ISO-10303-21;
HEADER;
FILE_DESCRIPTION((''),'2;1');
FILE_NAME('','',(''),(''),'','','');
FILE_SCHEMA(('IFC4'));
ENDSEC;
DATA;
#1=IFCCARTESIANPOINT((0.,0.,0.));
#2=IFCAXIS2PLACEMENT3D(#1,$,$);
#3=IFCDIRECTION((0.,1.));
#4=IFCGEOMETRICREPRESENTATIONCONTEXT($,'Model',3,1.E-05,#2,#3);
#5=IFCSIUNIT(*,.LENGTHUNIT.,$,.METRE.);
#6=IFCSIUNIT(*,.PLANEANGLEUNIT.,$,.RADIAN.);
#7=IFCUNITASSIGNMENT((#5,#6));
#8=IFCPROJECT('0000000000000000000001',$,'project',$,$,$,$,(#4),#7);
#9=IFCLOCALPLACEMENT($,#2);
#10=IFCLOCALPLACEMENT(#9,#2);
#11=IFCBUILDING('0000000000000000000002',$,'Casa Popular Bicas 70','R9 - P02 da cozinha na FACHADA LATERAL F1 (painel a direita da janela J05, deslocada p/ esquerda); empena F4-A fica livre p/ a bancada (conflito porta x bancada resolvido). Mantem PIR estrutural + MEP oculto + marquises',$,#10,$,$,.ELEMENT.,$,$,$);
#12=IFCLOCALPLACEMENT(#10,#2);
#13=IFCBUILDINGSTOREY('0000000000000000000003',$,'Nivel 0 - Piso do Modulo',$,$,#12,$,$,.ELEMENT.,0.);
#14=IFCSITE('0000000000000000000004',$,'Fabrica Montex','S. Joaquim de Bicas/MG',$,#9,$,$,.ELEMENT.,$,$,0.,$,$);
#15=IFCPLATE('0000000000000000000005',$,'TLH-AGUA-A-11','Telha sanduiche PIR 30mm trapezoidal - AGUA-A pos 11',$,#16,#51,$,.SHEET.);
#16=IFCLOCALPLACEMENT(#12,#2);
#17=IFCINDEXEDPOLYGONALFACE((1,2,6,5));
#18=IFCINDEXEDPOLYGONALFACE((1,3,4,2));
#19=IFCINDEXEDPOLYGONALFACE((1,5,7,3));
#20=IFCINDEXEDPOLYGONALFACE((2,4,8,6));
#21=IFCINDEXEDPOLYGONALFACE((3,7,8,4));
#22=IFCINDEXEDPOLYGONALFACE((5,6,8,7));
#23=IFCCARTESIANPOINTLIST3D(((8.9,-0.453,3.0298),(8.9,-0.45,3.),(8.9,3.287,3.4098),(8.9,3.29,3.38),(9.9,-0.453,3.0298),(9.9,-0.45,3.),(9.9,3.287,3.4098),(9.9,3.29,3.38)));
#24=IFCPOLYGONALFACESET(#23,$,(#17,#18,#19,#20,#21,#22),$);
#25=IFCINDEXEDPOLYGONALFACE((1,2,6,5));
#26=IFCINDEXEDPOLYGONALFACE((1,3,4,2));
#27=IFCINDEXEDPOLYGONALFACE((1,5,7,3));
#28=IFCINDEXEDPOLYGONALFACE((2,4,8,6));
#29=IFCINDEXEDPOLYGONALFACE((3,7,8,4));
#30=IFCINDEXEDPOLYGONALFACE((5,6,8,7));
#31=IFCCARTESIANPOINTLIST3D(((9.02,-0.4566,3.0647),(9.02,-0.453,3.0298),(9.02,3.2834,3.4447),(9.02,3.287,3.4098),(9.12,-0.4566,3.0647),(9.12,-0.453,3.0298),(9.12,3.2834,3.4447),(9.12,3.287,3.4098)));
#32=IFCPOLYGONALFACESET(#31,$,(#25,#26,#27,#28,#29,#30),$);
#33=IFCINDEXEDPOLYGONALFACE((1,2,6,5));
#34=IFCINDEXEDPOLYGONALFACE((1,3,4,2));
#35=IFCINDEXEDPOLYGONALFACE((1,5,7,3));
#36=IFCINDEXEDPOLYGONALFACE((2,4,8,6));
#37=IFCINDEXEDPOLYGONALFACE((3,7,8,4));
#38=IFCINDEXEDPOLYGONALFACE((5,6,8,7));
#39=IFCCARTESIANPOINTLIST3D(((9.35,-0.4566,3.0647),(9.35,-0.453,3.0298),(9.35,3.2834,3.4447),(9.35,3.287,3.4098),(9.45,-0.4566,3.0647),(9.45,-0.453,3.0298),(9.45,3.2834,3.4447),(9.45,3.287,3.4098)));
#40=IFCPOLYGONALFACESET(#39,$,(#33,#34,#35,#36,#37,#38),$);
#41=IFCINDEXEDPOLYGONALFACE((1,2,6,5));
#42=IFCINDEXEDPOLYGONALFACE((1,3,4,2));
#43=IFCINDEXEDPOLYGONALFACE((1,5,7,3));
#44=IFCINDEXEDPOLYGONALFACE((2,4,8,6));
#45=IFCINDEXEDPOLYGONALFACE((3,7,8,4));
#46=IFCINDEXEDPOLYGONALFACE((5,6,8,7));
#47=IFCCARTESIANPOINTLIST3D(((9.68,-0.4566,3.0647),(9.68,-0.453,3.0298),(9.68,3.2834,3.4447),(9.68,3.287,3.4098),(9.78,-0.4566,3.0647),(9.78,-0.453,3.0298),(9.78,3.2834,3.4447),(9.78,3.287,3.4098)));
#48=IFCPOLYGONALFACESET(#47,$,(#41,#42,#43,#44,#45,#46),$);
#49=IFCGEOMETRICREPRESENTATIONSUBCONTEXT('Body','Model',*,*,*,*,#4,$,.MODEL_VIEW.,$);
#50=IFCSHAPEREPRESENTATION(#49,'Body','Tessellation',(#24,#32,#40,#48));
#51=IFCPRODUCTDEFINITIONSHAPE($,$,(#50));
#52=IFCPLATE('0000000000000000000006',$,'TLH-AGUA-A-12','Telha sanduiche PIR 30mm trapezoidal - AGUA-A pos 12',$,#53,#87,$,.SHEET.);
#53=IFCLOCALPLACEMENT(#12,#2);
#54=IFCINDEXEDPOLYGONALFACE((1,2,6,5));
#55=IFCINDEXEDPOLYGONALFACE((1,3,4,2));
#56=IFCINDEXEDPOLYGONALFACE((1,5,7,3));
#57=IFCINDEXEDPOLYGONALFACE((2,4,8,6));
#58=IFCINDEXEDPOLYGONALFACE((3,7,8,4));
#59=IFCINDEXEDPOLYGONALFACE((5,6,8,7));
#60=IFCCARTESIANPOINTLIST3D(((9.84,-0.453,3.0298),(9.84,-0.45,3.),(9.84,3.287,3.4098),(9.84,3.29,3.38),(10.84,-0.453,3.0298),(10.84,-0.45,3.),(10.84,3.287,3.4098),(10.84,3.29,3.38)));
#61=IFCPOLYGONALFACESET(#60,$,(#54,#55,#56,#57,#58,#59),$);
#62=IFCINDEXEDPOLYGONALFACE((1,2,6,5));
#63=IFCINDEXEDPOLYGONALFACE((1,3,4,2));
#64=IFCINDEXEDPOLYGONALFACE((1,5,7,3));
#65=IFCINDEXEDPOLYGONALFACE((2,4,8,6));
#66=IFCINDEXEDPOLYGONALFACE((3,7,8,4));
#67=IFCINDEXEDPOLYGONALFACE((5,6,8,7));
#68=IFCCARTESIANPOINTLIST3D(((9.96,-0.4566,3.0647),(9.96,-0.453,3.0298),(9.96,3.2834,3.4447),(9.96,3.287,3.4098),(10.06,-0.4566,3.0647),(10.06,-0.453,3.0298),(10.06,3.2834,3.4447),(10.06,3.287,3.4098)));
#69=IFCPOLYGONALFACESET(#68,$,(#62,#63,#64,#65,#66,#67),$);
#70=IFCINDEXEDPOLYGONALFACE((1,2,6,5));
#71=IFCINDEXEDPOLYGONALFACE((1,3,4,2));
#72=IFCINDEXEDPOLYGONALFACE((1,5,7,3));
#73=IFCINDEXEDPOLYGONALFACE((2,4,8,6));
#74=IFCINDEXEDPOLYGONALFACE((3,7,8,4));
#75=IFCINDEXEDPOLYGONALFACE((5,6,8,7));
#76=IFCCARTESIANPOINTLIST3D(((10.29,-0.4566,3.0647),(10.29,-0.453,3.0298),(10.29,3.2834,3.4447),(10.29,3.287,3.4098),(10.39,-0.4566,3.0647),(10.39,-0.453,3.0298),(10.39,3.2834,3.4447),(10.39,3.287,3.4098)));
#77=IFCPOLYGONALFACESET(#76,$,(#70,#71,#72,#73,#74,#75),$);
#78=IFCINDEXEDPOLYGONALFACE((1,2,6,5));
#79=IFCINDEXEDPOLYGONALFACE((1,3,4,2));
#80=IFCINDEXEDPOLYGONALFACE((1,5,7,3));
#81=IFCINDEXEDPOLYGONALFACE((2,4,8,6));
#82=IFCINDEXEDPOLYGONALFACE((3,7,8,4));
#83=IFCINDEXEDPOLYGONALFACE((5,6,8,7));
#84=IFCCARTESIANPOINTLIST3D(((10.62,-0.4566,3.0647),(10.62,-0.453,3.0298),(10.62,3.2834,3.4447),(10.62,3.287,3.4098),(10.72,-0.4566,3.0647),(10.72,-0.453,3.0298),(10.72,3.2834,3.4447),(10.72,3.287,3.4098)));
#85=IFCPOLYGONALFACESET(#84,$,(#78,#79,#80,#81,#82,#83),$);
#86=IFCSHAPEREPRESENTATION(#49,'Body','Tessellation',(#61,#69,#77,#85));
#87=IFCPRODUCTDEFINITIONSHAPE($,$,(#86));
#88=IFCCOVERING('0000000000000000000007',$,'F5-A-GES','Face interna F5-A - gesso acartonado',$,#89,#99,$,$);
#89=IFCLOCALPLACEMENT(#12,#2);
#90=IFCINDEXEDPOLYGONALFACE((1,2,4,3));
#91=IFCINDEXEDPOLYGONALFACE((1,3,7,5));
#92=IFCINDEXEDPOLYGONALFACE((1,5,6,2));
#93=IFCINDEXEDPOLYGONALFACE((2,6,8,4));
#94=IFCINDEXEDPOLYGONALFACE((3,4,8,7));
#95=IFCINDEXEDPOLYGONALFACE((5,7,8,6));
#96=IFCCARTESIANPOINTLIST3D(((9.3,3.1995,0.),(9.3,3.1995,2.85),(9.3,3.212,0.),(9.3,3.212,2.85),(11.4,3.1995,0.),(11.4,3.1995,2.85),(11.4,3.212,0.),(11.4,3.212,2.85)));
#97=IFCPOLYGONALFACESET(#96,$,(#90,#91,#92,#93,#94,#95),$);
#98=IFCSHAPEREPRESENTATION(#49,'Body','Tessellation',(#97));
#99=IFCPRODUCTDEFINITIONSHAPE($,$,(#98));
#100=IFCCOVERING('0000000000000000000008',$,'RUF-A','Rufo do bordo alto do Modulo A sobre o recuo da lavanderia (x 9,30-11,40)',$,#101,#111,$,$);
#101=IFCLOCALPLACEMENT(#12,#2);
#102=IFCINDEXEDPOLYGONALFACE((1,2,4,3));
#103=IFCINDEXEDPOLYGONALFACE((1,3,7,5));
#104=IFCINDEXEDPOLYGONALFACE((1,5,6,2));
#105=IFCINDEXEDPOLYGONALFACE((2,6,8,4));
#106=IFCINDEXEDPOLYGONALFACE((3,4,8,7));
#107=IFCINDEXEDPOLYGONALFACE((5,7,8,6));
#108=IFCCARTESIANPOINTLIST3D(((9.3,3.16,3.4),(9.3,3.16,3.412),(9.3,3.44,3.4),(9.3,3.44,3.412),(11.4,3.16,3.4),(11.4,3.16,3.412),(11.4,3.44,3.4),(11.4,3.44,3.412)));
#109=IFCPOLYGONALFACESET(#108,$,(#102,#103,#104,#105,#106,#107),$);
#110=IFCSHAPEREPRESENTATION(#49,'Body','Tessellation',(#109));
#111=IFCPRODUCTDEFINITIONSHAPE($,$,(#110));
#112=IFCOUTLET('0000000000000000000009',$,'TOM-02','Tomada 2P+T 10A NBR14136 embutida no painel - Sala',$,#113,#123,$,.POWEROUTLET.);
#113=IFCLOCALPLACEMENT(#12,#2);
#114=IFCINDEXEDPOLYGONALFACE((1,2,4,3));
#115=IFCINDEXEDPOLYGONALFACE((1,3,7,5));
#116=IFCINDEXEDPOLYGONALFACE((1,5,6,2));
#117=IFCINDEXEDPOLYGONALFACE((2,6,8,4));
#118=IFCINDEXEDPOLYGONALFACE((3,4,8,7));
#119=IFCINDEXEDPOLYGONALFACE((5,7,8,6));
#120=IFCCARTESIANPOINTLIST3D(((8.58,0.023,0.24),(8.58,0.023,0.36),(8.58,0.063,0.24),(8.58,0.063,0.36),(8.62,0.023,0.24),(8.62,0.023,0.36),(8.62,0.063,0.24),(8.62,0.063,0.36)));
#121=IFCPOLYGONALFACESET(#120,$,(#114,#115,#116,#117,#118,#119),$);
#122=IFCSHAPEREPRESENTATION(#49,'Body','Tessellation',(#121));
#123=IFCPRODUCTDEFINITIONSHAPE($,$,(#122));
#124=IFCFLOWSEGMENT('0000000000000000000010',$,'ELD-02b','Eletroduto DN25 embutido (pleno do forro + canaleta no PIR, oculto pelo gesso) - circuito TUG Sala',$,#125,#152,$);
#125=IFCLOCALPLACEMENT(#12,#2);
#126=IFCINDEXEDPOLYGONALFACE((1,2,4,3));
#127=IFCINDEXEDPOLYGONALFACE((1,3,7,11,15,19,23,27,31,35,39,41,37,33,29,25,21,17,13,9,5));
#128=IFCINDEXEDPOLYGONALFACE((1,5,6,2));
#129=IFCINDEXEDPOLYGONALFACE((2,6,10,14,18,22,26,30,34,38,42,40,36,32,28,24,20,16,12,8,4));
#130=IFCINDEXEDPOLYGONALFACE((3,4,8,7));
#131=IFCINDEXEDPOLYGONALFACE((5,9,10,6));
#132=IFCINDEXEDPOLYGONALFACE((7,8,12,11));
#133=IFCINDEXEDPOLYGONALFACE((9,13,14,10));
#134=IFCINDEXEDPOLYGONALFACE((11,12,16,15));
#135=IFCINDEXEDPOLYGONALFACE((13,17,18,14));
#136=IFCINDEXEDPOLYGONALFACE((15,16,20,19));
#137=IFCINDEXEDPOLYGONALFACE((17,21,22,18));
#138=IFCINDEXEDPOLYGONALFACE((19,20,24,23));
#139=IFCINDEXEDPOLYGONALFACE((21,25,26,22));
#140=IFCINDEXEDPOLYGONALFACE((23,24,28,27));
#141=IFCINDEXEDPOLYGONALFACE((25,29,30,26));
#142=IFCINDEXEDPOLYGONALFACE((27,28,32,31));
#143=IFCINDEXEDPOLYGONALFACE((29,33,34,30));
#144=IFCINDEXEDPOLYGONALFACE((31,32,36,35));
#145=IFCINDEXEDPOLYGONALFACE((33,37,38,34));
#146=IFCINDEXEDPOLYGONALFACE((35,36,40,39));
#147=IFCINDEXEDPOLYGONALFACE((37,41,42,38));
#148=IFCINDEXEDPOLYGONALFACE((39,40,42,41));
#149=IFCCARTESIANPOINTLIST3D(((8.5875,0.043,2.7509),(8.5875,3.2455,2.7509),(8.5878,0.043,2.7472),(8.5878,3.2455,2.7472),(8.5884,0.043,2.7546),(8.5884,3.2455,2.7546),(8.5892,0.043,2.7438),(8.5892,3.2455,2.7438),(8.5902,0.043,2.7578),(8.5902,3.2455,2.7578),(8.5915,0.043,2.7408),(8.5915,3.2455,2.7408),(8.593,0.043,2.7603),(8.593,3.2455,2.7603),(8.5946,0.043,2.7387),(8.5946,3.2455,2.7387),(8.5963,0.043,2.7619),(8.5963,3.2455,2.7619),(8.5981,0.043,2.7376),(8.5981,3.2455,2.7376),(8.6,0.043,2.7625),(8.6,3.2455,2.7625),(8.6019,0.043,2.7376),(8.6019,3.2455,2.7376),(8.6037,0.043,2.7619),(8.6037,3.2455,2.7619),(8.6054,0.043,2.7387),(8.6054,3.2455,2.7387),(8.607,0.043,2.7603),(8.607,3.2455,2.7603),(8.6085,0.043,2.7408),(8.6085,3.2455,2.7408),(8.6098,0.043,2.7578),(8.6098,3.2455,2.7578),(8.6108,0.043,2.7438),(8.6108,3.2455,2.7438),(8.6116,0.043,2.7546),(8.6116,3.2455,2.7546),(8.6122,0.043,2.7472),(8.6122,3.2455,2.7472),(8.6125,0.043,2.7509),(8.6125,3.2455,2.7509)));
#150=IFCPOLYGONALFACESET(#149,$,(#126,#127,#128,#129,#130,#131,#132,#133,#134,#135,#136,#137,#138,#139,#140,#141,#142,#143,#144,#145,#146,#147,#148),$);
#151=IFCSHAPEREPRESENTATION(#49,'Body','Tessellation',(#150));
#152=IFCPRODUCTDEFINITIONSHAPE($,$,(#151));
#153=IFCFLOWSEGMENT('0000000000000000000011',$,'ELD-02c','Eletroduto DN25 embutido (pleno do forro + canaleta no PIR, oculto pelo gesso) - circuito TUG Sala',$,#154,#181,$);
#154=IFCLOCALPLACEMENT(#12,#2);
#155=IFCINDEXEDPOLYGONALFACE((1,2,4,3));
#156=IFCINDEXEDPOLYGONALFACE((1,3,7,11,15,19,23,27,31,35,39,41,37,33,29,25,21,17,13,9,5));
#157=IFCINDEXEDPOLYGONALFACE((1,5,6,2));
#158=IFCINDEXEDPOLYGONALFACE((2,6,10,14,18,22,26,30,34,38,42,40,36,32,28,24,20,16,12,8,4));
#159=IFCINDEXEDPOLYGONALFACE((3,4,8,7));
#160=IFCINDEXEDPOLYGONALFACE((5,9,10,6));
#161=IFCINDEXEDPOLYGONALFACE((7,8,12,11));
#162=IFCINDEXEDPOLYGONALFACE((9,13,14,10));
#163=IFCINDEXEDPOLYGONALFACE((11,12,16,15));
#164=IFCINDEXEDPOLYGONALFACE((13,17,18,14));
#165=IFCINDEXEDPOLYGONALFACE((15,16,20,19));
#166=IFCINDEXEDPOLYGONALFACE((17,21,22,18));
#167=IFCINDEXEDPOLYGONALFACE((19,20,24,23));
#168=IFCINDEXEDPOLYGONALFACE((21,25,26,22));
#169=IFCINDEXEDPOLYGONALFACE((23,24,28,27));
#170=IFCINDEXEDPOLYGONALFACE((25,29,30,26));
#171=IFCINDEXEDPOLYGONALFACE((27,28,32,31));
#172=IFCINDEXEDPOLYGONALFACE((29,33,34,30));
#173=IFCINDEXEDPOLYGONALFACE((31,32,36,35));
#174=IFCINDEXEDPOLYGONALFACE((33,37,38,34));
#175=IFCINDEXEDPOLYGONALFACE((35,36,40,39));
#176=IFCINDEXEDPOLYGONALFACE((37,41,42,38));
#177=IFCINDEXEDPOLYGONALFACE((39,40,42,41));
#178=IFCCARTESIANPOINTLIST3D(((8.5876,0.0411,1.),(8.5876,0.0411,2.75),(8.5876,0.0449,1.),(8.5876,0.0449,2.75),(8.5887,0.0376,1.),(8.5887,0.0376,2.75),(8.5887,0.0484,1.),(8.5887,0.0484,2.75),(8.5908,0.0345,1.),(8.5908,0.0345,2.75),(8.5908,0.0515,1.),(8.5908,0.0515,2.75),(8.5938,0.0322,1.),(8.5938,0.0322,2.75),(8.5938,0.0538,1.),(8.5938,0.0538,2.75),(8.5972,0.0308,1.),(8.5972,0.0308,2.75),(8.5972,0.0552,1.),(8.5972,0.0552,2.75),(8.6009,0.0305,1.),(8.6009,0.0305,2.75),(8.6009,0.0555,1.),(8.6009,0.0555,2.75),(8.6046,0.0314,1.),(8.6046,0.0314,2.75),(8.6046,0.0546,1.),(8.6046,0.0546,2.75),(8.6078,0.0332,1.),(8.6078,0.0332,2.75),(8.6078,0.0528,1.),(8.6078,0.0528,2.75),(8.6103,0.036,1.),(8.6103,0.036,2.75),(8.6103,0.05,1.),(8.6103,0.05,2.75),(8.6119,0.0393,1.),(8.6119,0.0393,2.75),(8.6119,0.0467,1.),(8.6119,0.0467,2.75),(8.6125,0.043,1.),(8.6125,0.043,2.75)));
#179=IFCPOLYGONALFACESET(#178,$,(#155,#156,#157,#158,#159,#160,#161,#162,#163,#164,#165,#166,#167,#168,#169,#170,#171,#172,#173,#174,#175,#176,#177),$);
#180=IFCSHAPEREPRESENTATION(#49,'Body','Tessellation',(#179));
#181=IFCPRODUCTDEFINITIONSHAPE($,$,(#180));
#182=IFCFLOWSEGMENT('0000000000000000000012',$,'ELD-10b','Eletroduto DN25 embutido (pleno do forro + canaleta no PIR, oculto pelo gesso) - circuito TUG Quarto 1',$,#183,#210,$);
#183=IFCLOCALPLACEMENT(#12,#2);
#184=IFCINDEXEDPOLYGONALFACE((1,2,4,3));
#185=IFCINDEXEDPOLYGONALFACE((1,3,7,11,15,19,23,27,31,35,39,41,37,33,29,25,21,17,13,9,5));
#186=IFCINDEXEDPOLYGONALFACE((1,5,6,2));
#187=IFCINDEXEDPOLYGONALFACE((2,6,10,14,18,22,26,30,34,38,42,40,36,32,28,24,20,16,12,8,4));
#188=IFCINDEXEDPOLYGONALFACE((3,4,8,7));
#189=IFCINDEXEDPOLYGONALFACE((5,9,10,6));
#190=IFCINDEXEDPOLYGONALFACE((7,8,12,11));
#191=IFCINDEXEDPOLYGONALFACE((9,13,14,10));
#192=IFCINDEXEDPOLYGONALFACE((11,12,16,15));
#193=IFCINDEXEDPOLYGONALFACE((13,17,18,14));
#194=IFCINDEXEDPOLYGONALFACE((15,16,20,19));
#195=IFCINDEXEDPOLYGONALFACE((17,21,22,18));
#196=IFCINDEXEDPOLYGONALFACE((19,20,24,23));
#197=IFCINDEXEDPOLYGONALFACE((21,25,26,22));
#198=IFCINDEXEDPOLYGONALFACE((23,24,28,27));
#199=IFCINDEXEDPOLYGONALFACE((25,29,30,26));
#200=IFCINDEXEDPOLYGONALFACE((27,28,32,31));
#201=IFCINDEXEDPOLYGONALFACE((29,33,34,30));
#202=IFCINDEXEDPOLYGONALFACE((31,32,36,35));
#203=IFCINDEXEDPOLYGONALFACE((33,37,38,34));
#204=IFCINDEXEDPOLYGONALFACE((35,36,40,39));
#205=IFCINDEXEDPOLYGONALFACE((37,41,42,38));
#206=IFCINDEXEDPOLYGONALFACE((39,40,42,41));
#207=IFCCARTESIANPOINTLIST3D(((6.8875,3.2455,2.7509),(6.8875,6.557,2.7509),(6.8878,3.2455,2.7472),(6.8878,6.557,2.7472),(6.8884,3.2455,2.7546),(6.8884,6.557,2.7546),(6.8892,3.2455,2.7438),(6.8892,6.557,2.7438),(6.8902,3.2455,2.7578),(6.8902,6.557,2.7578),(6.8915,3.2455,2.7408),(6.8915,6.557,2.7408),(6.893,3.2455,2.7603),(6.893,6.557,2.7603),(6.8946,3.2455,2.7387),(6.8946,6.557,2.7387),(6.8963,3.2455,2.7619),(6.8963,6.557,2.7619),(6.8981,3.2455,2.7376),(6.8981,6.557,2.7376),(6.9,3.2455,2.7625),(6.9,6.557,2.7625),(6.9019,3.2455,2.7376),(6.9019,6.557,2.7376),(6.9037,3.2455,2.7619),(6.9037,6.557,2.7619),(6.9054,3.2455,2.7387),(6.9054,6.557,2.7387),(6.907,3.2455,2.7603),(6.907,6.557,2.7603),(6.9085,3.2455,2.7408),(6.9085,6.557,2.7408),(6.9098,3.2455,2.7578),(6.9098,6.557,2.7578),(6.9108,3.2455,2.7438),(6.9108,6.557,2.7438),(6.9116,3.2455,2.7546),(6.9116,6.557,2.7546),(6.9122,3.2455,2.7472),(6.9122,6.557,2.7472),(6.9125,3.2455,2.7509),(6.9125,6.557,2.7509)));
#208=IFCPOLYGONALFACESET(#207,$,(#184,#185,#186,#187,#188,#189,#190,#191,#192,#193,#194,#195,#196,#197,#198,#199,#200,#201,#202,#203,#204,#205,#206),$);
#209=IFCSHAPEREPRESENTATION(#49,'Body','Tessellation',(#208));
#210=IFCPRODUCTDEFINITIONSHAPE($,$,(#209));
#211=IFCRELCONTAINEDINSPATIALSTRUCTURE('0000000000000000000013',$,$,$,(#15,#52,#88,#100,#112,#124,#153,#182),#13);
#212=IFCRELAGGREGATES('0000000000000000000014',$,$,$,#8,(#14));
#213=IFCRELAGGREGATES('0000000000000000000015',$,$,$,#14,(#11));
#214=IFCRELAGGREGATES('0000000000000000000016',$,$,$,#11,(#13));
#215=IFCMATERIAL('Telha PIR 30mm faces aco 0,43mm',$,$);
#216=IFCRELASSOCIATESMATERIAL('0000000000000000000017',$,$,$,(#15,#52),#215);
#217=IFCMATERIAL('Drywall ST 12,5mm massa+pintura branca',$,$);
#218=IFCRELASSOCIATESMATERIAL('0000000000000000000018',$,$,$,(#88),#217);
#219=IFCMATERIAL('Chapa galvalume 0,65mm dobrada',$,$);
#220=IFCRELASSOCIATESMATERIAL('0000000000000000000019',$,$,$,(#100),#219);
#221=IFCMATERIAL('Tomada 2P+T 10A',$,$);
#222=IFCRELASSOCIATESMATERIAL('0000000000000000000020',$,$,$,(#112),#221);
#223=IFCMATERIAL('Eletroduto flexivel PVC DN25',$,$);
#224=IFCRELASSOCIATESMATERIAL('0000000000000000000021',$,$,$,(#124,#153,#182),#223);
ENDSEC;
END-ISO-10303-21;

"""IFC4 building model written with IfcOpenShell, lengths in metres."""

from ifc_helpers import new_model, si_unit, direction, frame, frame_2d, origin, origin_2d, place, context, subcontext, project, spatial, rectangle, circle, extrude, material, element, save


model = new_model("IFC4")

# Units and contexts
model_context = context("Model", 3, precision=1e-05, world=origin(), true_north=direction((0.0, 1.0)))
body_context = subcontext(model_context, "Body", "Model", "MODEL_VIEW")
ifc_project = project(units=[si_unit("LENGTHUNIT", "METRE"), si_unit("PLANEANGLEUNIT", "RADIAN")], contexts=[model_context])

# Site, building, storey
site_placement = place(None, origin())
site = spatial("IfcSite", under=ifc_project, at=site_placement, Name="Fabrica Montex", Description="S. Joaquim de Bicas/MG", CompositionType="ELEMENT", RefElevation=0.0)
building_placement = place(site_placement, origin())
building = spatial("IfcBuilding", under=site, at=building_placement, Name="Casa Popular Bicas 70", Description="R9 - P02 da cozinha na FACHADA LATERAL F1 (painel a direita da janela J05, deslocada p/ esquerda); empena F4-A fica livre p/ a bancada (conflito porta x bancada resolvido). Mantem PIR estrutural + MEP oculto + marquises", CompositionType="ELEMENT")
storey_placement = place(building_placement, origin())
storey = spatial("IfcBuildingStorey", under=building, at=storey_placement, Name="Nivel 0 - Piso do Modulo", CompositionType="ELEMENT", Elevation=0.0)

# Plates
ifc_material_1 = material(Name="Telha PIR 30mm faces aco 0,43mm")
for number, where, z_axis, x_axis, name, description in (
    (1, (8.9, -0.45, 3.0), (0.0, -0.101084, 0.994878), (1.0, 0.0, 0.0), "TLH-AGUA-A-11", "Telha sanduiche PIR 30mm trapezoidal - AGUA-A pos 11"),
    (2, (9.84, -0.45, 3.0), (0.0, -0.101084, 0.994878), (1.0, 0.0, 0.0), "TLH-AGUA-A-12", "Telha sanduiche PIR 30mm trapezoidal - AGUA-A pos 12"),
):
    element("IfcPlate", number, at=place(storey_placement, frame(where, z_axis=z_axis, x_axis=x_axis)), inside=storey, material=ifc_material_1, Name=name, Description=description, PredefinedType="SHEET", context=body_context, shape_type="SweptSolid", body=[
        extrude(rectangle(XDim=1.0, YDim=3.7593, at=frame_2d((0.5, 1.8796))), origin(), (0.0, 0.0, 1.0), 0.03),
        extrude(rectangle(XDim=0.1, YDim=3.7593, at=frame_2d((0.17, 1.8796))), frame((0.0, 0.0, 0.03)), (0.0, 0.0, 1.0), 0.035),
        extrude(rectangle(XDim=0.1, YDim=3.7593, at=frame_2d((0.5, 1.8796))), frame((0.0, 0.0, 0.03)), (0.0, 0.0, 1.0), 0.035),
        extrude(rectangle(XDim=0.1, YDim=3.7593, at=frame_2d((0.83, 1.8796))), frame((0.0, 0.0, 0.03)), (0.0, 0.0, 1.0), 0.035),
    ])

# Coverings
ifc_material_2 = material(Name="Drywall ST 12,5mm massa+pintura branca")
covering_1_placement = place(storey_placement, frame((9.3, 3.2058, 0.0), x_axis=(1.0, 0.0, 0.0)))
element("IfcCovering", 3, at=covering_1_placement, inside=storey, material=ifc_material_2, Name="F5-A-GES", Description="Face interna F5-A - gesso acartonado", context=body_context, shape_type="SweptSolid", body=[
    extrude(rectangle(XDim=2.1, YDim=0.0125, at=frame_2d((1.05, 0.0))), origin(), (0.0, 0.0, 1.0), 2.85),
])
ifc_material_3 = material(Name="Chapa galvalume 0,65mm dobrada")
covering_2_placement = place(storey_placement, frame((9.3, 3.16, 3.4), x_axis=(1.0, 0.0, 0.0)))
element("IfcCovering", 4, at=covering_2_placement, inside=storey, material=ifc_material_3, Name="RUF-A", Description="Rufo do bordo alto do Modulo A sobre o recuo da lavanderia (x 9,30-11,40)", context=body_context, shape_type="SweptSolid", body=[
    extrude(rectangle(XDim=2.1, YDim=0.28, at=frame_2d((1.05, 0.14))), origin(), (0.0, 0.0, 1.0), 0.012),
])

# Outlet
ifc_material_4 = material(Name="Tomada 2P+T 10A")
outlet_placement = place(storey_placement, frame((8.58, 0.023, 0.24)))
element("IfcOutlet", 5, at=outlet_placement, inside=storey, material=ifc_material_4, Name="TOM-02", Description="Tomada 2P+T 10A NBR14136 embutida no painel - Sala", PredefinedType="POWEROUTLET", context=body_context, shape_type="SweptSolid", body=[
    extrude(rectangle(XDim=0.04, YDim=0.04, at=frame_2d((0.02, 0.02))), origin(), (0.0, 0.0, 1.0), 0.12),
])

# Flow segments
ifc_material_5 = material(Name="Eletroduto flexivel PVC DN25")
flow_segment_1_placement = place(storey_placement, frame((8.6, 3.2455, 2.75), z_axis=(0.0, -1.0, 0.0), x_axis=(0.0, 0.0, 1.0)))
element("IfcFlowSegment", 6, at=flow_segment_1_placement, inside=storey, material=ifc_material_5, Name="ELD-02b", Description="Eletroduto DN25 embutido (pleno do forro + canaleta no PIR, oculto pelo gesso) - circuito TUG Sala", context=body_context, shape_type="SweptSolid", body=[
    extrude(circle(Radius=0.0125, at=origin_2d()), origin(), (0.0, 0.0, 1.0), 3.2025),
])
flow_segment_2_placement = place(storey_placement, frame((8.6, 0.043, 2.75), z_axis=(0.0, 0.0, -1.0), x_axis=(1.0, 0.0, 0.0)))
element("IfcFlowSegment", 7, at=flow_segment_2_placement, inside=storey, material=ifc_material_5, Name="ELD-02c", Description="Eletroduto DN25 embutido (pleno do forro + canaleta no PIR, oculto pelo gesso) - circuito TUG Sala", context=body_context, shape_type="SweptSolid", body=[
    extrude(circle(Radius=0.0125, at=origin_2d()), origin(), (0.0, 0.0, 1.0), 1.75),
])
flow_segment_3_placement = place(storey_placement, frame((6.9, 3.2455, 2.75), z_axis=(0.0, 1.0, 0.0), x_axis=(0.0, 0.0, 1.0)))
element("IfcFlowSegment", 8, at=flow_segment_3_placement, inside=storey, material=ifc_material_5, Name="ELD-10b", Description="Eletroduto DN25 embutido (pleno do forro + canaleta no PIR, oculto pelo gesso) - circuito TUG Quarto 1", context=body_context, shape_type="SweptSolid", body=[
    extrude(circle(Radius=0.0125, at=origin_2d()), origin(), (0.0, 0.0, 1.0), 3.3115),
])

save(model, "model.ifc")
